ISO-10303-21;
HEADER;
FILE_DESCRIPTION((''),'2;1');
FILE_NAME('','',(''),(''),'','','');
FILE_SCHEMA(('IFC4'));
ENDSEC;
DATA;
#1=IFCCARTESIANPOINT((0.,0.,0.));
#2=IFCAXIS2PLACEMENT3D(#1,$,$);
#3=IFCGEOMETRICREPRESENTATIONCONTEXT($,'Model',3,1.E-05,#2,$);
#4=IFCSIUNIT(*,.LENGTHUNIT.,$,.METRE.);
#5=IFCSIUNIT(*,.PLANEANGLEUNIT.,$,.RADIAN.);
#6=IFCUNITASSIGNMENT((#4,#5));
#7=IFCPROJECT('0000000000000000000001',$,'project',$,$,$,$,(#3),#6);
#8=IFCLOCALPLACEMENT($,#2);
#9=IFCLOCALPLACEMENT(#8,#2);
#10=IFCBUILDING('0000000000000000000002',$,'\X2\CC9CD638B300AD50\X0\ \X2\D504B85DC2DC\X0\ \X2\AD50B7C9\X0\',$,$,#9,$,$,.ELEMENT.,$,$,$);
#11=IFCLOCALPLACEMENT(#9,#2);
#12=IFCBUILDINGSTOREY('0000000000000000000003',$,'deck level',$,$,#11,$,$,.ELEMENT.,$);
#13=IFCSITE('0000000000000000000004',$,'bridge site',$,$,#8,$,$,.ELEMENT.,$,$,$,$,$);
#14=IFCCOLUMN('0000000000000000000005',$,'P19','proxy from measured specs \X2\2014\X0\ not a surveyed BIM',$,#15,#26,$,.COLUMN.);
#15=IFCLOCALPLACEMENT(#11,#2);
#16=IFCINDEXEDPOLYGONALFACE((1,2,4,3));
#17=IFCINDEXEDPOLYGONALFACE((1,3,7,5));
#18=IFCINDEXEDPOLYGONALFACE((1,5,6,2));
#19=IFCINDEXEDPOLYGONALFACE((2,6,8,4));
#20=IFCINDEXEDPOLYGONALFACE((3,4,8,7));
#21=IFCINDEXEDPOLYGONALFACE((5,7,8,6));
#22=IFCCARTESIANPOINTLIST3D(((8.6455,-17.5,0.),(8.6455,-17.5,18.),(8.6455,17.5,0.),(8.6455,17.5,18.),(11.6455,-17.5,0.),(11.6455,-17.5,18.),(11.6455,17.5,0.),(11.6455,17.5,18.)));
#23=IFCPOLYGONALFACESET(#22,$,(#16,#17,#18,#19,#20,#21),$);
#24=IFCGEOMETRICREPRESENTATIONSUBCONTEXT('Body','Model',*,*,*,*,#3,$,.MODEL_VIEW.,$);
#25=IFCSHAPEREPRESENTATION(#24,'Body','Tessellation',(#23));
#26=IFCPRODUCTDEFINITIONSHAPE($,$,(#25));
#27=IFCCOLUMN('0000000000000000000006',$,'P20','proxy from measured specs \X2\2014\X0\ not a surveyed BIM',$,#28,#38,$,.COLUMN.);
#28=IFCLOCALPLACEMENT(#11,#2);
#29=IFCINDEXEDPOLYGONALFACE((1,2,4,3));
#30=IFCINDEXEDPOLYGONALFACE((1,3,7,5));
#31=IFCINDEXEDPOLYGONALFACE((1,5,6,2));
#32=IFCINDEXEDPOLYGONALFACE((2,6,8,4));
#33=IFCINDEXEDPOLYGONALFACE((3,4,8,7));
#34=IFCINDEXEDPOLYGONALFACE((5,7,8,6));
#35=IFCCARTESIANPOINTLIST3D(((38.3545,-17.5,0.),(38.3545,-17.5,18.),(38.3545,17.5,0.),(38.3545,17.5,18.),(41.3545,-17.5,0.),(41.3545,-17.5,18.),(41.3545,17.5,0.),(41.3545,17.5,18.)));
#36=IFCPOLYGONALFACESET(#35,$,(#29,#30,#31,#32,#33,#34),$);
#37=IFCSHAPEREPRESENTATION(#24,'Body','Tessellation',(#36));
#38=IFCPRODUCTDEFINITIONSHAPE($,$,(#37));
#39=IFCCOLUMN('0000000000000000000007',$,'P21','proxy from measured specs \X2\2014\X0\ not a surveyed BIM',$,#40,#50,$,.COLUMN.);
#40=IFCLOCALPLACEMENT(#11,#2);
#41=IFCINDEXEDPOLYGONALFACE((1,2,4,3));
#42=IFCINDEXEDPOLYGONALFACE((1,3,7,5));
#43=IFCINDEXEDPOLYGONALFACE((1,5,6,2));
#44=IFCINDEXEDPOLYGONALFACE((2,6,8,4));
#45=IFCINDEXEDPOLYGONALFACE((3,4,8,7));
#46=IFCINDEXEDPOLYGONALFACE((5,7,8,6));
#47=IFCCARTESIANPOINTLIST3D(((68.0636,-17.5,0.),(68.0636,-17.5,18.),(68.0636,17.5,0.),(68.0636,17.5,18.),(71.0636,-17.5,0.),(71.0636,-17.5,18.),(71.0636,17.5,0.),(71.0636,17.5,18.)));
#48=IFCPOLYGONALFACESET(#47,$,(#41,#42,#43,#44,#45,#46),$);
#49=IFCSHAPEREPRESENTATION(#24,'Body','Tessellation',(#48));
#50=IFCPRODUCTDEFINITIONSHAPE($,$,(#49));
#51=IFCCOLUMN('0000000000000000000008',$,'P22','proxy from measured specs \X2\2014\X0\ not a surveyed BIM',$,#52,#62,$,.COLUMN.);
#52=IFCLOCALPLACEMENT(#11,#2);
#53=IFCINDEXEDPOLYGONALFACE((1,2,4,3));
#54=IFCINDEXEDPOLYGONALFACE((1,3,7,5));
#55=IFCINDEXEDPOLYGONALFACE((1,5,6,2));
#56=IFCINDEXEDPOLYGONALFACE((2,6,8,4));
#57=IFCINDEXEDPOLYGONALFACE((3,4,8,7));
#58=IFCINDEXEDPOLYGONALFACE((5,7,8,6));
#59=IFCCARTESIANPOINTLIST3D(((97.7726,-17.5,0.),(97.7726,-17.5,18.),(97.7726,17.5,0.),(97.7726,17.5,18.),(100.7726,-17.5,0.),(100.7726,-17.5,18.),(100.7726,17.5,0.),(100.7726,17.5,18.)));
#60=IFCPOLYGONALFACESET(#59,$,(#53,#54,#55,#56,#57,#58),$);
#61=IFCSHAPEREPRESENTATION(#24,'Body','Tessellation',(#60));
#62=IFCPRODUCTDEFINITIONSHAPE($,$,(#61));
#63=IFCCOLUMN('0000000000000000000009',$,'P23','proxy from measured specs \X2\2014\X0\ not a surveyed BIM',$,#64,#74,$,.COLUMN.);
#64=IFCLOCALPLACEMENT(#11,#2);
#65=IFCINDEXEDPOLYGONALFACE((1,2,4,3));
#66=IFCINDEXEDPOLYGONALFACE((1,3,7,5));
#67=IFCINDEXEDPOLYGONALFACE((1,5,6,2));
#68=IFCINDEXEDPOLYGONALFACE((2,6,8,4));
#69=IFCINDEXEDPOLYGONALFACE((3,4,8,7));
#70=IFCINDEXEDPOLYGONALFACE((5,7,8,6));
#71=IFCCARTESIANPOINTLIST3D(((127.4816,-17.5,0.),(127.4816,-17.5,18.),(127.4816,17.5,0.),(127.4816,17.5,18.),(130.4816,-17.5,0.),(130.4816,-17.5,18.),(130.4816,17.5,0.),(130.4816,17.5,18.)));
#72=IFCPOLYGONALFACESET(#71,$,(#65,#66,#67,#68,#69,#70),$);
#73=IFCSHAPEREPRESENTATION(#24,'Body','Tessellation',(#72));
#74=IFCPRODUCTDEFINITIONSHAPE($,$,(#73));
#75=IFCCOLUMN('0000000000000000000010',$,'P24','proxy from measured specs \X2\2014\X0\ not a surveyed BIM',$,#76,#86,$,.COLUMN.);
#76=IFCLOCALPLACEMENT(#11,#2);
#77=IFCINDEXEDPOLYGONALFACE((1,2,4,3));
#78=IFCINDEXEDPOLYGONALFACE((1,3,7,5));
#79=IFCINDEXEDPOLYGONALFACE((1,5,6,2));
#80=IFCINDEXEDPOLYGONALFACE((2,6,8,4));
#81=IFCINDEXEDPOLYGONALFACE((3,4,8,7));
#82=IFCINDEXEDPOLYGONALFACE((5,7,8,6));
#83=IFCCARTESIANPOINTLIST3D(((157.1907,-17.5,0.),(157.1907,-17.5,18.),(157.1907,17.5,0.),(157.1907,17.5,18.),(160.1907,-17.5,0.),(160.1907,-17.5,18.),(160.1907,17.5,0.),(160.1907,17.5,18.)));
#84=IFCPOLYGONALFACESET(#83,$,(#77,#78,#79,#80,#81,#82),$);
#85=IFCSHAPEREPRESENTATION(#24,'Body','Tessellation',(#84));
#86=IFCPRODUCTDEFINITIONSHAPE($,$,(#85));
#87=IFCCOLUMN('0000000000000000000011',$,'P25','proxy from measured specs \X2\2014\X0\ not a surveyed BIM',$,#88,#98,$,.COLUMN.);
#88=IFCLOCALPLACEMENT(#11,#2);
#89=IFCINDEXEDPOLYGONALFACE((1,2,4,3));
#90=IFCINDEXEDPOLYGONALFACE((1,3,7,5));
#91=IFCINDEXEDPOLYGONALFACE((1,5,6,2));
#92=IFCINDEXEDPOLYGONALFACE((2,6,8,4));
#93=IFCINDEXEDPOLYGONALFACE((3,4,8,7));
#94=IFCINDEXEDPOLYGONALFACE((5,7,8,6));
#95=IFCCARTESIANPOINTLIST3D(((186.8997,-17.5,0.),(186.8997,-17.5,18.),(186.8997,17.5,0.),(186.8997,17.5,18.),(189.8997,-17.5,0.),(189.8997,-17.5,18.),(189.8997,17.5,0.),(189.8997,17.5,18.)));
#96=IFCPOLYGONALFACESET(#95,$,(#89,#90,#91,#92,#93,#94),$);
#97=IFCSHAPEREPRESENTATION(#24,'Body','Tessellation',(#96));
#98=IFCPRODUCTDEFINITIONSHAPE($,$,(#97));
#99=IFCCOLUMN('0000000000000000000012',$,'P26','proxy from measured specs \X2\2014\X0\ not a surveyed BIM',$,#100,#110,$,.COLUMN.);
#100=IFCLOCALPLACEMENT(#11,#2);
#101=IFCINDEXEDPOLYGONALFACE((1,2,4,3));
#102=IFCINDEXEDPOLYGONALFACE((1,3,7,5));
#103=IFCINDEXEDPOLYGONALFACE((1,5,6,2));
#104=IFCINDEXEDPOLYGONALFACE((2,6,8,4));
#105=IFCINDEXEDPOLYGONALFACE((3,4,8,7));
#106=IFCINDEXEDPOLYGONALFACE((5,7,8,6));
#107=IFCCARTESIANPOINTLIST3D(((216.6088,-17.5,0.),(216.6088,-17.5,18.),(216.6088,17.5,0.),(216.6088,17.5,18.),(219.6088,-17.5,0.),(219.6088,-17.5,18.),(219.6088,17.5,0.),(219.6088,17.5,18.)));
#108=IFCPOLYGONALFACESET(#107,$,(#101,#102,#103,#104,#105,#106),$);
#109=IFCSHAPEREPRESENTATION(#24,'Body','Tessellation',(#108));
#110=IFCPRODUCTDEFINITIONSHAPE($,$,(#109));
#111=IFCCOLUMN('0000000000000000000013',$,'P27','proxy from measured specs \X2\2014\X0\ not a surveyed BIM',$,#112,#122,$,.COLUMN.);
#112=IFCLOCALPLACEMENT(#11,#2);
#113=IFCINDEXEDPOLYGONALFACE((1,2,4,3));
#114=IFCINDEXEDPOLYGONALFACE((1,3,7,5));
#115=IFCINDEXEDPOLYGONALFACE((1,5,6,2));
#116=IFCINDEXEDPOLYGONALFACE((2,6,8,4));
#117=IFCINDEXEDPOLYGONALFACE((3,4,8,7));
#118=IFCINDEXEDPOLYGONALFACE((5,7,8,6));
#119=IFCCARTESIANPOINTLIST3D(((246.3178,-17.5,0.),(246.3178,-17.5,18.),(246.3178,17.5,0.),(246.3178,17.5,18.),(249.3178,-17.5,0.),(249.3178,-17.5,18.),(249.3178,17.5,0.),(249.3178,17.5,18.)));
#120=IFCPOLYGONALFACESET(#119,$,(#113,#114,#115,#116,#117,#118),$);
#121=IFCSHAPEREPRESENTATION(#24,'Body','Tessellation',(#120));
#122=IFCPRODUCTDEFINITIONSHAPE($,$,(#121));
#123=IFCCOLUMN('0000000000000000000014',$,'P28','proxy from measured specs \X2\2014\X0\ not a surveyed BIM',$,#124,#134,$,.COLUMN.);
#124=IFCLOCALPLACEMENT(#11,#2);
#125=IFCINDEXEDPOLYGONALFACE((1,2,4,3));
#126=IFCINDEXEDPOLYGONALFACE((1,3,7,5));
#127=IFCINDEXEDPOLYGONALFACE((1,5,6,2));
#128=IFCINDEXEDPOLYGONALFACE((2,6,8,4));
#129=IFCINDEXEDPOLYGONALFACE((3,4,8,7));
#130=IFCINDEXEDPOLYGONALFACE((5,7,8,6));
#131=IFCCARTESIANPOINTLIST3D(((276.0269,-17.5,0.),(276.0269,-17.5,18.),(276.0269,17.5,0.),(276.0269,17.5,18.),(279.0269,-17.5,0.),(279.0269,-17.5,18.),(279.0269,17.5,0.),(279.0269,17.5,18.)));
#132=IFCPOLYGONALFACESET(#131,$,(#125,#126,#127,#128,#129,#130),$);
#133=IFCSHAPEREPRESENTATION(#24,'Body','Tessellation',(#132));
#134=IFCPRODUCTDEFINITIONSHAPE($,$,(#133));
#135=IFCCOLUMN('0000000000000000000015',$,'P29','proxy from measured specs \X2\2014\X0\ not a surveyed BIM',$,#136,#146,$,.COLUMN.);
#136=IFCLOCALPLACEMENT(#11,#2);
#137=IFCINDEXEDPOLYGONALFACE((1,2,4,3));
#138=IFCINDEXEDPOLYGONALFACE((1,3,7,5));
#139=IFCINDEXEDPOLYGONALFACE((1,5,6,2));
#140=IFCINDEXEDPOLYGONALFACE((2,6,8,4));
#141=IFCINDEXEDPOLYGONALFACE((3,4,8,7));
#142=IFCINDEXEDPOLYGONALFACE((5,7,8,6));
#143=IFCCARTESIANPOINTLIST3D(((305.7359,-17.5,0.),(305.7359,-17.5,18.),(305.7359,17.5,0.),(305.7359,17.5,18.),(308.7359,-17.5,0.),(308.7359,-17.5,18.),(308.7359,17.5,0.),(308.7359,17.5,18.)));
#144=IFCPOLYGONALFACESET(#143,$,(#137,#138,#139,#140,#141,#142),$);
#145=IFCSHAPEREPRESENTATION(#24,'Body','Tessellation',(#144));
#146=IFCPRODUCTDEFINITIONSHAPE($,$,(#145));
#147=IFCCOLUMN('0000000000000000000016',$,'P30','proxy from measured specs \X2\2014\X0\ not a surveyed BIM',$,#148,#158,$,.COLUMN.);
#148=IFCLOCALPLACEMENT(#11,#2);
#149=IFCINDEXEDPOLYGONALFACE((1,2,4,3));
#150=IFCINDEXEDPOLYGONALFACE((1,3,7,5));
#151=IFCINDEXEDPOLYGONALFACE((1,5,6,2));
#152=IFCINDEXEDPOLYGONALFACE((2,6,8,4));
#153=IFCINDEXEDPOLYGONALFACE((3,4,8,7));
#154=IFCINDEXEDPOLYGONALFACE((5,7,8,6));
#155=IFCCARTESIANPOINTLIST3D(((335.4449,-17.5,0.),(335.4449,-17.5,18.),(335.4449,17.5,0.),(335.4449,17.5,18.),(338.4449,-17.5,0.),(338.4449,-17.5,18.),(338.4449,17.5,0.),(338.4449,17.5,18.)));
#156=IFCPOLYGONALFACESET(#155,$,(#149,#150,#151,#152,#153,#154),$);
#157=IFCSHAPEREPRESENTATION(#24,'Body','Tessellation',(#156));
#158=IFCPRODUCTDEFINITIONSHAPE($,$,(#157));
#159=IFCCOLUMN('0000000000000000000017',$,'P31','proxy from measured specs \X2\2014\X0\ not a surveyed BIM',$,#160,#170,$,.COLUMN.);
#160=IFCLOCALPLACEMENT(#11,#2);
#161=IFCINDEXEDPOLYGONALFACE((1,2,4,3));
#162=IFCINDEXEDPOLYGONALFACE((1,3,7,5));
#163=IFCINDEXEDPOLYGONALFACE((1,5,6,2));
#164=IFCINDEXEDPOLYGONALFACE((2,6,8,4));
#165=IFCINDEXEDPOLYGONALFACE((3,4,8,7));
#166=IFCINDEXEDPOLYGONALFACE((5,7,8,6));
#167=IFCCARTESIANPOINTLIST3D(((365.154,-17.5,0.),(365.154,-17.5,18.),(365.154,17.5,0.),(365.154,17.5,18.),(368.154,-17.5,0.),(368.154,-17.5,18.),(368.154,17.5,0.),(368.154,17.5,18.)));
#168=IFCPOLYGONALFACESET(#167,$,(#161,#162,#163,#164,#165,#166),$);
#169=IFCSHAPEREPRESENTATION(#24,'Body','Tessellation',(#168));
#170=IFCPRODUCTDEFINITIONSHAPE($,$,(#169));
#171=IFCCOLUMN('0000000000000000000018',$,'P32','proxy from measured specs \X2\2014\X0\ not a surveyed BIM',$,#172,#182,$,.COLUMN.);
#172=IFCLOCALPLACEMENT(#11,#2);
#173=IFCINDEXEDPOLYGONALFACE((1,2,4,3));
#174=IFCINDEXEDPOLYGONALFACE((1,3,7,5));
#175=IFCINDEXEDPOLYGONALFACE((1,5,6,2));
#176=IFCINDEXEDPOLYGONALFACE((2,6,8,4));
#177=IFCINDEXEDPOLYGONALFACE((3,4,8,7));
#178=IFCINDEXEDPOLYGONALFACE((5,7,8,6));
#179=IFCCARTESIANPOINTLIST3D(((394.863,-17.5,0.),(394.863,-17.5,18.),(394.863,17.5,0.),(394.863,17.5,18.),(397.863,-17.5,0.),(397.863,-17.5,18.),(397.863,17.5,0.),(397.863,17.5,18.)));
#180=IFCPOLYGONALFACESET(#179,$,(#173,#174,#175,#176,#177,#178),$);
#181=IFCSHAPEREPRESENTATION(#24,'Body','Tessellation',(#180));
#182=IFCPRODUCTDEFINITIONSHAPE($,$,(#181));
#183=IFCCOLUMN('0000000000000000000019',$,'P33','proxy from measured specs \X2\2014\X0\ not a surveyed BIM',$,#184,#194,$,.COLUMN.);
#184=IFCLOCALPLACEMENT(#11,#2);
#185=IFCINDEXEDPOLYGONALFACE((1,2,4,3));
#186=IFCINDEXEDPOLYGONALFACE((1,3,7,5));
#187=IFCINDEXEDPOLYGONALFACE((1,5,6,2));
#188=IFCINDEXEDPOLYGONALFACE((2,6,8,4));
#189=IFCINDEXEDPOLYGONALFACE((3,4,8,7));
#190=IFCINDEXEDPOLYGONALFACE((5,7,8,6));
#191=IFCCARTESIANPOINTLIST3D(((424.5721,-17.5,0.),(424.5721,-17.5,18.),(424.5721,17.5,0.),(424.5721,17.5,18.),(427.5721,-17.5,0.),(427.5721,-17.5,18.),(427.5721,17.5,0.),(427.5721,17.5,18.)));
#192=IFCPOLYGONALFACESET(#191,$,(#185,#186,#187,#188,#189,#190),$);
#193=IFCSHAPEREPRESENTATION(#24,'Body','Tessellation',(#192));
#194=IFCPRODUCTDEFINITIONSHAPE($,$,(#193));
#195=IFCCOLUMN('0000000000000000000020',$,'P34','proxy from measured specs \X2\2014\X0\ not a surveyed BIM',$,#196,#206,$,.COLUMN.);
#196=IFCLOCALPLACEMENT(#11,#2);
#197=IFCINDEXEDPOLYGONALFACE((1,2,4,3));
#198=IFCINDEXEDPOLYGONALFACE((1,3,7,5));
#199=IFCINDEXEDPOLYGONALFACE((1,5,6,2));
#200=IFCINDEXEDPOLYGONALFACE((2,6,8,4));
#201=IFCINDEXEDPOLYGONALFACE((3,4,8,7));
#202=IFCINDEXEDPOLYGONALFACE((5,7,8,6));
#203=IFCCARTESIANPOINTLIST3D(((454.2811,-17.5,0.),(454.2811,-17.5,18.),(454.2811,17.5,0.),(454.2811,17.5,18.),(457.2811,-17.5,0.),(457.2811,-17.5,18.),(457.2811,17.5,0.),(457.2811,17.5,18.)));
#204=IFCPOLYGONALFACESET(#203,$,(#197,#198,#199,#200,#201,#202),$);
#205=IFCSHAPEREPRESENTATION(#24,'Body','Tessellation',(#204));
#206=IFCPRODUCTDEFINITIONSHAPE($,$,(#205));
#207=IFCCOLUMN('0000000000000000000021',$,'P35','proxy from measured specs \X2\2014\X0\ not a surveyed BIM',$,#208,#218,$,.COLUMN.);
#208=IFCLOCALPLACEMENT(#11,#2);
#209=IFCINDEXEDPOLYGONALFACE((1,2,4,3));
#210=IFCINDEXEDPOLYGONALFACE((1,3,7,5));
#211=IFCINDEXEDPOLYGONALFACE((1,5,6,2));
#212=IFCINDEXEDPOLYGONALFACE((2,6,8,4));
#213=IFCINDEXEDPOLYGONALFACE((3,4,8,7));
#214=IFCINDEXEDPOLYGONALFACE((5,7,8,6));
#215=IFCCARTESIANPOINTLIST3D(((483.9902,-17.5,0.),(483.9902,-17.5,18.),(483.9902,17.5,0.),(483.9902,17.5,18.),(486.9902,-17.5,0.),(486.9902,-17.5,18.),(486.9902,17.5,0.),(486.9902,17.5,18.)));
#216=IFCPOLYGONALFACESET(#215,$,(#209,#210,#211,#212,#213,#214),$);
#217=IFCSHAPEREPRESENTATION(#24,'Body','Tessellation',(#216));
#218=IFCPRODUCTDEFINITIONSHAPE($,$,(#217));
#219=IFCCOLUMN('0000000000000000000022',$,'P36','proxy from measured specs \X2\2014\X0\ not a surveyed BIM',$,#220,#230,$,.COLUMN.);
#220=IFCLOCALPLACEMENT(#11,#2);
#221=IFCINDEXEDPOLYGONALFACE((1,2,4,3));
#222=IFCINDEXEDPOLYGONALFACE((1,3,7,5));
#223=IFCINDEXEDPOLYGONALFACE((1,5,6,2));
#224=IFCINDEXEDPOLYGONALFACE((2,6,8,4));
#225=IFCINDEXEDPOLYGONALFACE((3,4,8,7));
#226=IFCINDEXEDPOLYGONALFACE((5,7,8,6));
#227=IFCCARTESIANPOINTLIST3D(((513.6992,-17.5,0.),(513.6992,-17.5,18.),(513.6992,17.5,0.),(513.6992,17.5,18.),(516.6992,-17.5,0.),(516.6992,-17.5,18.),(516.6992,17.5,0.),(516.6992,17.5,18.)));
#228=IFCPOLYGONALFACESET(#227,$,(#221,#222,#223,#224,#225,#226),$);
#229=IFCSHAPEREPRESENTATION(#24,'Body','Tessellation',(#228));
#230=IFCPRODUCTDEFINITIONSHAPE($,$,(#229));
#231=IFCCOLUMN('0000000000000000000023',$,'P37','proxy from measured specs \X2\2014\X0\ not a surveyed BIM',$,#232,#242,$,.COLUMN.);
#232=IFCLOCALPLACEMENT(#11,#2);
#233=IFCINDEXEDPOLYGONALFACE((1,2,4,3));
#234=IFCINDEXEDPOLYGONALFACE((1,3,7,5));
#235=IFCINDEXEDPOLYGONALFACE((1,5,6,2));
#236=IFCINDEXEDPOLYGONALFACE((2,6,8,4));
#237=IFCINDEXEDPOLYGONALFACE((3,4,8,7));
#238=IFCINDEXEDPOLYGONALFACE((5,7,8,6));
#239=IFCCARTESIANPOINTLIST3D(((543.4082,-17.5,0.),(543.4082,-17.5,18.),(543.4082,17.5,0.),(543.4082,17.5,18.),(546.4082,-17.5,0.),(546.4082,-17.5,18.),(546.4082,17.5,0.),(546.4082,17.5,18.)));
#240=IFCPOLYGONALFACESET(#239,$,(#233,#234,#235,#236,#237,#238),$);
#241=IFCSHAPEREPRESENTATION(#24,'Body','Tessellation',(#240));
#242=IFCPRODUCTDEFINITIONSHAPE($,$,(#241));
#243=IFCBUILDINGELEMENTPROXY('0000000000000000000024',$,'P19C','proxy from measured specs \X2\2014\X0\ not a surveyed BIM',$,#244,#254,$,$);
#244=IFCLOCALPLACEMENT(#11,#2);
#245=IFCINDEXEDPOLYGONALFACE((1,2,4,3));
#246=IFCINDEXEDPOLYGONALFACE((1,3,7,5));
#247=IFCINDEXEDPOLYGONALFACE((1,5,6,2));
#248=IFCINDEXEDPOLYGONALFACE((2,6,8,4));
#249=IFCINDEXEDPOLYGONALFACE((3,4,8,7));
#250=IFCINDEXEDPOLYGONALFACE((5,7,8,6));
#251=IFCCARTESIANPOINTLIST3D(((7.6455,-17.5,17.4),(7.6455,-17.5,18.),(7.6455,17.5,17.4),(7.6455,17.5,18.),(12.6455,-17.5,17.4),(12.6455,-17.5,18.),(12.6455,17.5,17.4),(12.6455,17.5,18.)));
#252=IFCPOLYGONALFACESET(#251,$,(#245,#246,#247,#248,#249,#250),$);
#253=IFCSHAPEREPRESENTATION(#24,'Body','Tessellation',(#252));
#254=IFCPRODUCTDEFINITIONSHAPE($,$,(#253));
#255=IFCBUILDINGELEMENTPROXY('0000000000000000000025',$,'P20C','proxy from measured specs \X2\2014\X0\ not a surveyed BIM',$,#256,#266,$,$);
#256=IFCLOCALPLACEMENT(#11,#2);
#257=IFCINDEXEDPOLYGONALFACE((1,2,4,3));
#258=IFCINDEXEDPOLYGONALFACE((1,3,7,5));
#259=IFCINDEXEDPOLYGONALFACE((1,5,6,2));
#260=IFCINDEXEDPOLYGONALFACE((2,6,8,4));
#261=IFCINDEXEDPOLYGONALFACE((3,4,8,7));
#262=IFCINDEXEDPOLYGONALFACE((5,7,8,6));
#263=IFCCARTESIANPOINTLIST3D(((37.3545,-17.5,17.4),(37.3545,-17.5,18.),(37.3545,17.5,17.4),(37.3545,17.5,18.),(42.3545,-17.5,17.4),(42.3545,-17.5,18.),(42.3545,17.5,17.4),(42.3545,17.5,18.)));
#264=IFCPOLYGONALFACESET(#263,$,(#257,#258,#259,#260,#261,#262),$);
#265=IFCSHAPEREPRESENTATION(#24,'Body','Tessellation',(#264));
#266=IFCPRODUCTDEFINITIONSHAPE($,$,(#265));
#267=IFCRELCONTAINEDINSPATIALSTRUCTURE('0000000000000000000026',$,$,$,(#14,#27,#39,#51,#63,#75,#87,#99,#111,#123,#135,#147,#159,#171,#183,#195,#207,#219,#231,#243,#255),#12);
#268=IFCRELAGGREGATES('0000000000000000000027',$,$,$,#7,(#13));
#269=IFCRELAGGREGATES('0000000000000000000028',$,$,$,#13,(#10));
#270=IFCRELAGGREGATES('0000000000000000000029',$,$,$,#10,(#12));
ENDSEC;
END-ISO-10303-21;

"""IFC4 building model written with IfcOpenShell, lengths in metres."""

from ifc_helpers import new_model, si_unit, frame, origin, origin_2d, place, context, subcontext, project, spatial, rectangle, extrude, element, save


model = new_model("IFC4")

# Units and contexts
model_context = context("Model", 3, precision=1e-05, world=origin())
body_context = subcontext(model_context, "Body", "Model", "MODEL_VIEW")
ifc_project = project(units=[si_unit("LENGTHUNIT", "METRE"), si_unit("PLANEANGLEUNIT", "RADIAN")], contexts=[model_context])

# Site, building, storey
site_placement = place(None, origin())
site = spatial("IfcSite", under=ifc_project, at=site_placement, Name="bridge site", CompositionType="ELEMENT")
building_placement = place(site_placement, origin())
building = spatial("IfcBuilding", under=site, at=building_placement, Name="천호대교 프록시 교량", CompositionType="ELEMENT")
storey_placement = place(building_placement, origin())
storey = spatial("IfcBuildingStorey", under=building, at=storey_placement, Name="deck level", CompositionType="ELEMENT")

# Columns
for number, where, name in (
    (1, (10.1455, 0.0, 0.0), "P19"),
    (2, (39.8545, 0.0, 0.0), "P20"),
    (3, (69.5636, 0.0, 0.0), "P21"),
    (4, (99.2726, 0.0, 0.0), "P22"),
    (5, (128.9816, 0.0, 0.0), "P23"),
    (6, (158.6907, 0.0, 0.0), "P24"),
    (7, (188.3997, 0.0, 0.0), "P25"),
    (8, (218.1088, 0.0, 0.0), "P26"),
    (9, (247.8178, 0.0, 0.0), "P27"),
    (10, (277.5269, 0.0, 0.0), "P28"),
    (11, (307.2359, 0.0, 0.0), "P29"),
    (12, (336.9449, 0.0, 0.0), "P30"),
    (13, (366.654, 0.0, 0.0), "P31"),
    (14, (396.363, 0.0, 0.0), "P32"),
    (15, (426.0721, 0.0, 0.0), "P33"),
    (16, (455.7811, 0.0, 0.0), "P34"),
    (17, (485.4902, 0.0, 0.0), "P35"),
    (18, (515.1992, 0.0, 0.0), "P36"),
    (19, (544.9082, 0.0, 0.0), "P37"),
):
    element("IfcColumn", number, at=place(storey_placement, frame(where)), inside=storey, Name=name, Description="proxy from measured specs — not a surveyed BIM", PredefinedType="COLUMN", context=body_context, shape_type="SweptSolid", body=[
        extrude(rectangle(XDim=3.0, YDim=35.0, at=origin_2d()), origin(), (0.0, 0.0, 1.0), 18.0),
    ])

# Building element proxies
for number, where, name in (
    (20, (10.1455, 0.0, 17.4), "P19C"),
    (21, (39.8545, 0.0, 17.4), "P20C"),
):
    element("IfcBuildingElementProxy", number, at=place(storey_placement, frame(where)), inside=storey, Name=name, Description="proxy from measured specs — not a surveyed BIM", context=body_context, shape_type="SweptSolid", body=[
        extrude(rectangle(XDim=5.0, YDim=35.0, at=origin_2d()), origin(), (0.0, 0.0, 1.0), 0.6),
    ])

save(model, "model.ifc")
